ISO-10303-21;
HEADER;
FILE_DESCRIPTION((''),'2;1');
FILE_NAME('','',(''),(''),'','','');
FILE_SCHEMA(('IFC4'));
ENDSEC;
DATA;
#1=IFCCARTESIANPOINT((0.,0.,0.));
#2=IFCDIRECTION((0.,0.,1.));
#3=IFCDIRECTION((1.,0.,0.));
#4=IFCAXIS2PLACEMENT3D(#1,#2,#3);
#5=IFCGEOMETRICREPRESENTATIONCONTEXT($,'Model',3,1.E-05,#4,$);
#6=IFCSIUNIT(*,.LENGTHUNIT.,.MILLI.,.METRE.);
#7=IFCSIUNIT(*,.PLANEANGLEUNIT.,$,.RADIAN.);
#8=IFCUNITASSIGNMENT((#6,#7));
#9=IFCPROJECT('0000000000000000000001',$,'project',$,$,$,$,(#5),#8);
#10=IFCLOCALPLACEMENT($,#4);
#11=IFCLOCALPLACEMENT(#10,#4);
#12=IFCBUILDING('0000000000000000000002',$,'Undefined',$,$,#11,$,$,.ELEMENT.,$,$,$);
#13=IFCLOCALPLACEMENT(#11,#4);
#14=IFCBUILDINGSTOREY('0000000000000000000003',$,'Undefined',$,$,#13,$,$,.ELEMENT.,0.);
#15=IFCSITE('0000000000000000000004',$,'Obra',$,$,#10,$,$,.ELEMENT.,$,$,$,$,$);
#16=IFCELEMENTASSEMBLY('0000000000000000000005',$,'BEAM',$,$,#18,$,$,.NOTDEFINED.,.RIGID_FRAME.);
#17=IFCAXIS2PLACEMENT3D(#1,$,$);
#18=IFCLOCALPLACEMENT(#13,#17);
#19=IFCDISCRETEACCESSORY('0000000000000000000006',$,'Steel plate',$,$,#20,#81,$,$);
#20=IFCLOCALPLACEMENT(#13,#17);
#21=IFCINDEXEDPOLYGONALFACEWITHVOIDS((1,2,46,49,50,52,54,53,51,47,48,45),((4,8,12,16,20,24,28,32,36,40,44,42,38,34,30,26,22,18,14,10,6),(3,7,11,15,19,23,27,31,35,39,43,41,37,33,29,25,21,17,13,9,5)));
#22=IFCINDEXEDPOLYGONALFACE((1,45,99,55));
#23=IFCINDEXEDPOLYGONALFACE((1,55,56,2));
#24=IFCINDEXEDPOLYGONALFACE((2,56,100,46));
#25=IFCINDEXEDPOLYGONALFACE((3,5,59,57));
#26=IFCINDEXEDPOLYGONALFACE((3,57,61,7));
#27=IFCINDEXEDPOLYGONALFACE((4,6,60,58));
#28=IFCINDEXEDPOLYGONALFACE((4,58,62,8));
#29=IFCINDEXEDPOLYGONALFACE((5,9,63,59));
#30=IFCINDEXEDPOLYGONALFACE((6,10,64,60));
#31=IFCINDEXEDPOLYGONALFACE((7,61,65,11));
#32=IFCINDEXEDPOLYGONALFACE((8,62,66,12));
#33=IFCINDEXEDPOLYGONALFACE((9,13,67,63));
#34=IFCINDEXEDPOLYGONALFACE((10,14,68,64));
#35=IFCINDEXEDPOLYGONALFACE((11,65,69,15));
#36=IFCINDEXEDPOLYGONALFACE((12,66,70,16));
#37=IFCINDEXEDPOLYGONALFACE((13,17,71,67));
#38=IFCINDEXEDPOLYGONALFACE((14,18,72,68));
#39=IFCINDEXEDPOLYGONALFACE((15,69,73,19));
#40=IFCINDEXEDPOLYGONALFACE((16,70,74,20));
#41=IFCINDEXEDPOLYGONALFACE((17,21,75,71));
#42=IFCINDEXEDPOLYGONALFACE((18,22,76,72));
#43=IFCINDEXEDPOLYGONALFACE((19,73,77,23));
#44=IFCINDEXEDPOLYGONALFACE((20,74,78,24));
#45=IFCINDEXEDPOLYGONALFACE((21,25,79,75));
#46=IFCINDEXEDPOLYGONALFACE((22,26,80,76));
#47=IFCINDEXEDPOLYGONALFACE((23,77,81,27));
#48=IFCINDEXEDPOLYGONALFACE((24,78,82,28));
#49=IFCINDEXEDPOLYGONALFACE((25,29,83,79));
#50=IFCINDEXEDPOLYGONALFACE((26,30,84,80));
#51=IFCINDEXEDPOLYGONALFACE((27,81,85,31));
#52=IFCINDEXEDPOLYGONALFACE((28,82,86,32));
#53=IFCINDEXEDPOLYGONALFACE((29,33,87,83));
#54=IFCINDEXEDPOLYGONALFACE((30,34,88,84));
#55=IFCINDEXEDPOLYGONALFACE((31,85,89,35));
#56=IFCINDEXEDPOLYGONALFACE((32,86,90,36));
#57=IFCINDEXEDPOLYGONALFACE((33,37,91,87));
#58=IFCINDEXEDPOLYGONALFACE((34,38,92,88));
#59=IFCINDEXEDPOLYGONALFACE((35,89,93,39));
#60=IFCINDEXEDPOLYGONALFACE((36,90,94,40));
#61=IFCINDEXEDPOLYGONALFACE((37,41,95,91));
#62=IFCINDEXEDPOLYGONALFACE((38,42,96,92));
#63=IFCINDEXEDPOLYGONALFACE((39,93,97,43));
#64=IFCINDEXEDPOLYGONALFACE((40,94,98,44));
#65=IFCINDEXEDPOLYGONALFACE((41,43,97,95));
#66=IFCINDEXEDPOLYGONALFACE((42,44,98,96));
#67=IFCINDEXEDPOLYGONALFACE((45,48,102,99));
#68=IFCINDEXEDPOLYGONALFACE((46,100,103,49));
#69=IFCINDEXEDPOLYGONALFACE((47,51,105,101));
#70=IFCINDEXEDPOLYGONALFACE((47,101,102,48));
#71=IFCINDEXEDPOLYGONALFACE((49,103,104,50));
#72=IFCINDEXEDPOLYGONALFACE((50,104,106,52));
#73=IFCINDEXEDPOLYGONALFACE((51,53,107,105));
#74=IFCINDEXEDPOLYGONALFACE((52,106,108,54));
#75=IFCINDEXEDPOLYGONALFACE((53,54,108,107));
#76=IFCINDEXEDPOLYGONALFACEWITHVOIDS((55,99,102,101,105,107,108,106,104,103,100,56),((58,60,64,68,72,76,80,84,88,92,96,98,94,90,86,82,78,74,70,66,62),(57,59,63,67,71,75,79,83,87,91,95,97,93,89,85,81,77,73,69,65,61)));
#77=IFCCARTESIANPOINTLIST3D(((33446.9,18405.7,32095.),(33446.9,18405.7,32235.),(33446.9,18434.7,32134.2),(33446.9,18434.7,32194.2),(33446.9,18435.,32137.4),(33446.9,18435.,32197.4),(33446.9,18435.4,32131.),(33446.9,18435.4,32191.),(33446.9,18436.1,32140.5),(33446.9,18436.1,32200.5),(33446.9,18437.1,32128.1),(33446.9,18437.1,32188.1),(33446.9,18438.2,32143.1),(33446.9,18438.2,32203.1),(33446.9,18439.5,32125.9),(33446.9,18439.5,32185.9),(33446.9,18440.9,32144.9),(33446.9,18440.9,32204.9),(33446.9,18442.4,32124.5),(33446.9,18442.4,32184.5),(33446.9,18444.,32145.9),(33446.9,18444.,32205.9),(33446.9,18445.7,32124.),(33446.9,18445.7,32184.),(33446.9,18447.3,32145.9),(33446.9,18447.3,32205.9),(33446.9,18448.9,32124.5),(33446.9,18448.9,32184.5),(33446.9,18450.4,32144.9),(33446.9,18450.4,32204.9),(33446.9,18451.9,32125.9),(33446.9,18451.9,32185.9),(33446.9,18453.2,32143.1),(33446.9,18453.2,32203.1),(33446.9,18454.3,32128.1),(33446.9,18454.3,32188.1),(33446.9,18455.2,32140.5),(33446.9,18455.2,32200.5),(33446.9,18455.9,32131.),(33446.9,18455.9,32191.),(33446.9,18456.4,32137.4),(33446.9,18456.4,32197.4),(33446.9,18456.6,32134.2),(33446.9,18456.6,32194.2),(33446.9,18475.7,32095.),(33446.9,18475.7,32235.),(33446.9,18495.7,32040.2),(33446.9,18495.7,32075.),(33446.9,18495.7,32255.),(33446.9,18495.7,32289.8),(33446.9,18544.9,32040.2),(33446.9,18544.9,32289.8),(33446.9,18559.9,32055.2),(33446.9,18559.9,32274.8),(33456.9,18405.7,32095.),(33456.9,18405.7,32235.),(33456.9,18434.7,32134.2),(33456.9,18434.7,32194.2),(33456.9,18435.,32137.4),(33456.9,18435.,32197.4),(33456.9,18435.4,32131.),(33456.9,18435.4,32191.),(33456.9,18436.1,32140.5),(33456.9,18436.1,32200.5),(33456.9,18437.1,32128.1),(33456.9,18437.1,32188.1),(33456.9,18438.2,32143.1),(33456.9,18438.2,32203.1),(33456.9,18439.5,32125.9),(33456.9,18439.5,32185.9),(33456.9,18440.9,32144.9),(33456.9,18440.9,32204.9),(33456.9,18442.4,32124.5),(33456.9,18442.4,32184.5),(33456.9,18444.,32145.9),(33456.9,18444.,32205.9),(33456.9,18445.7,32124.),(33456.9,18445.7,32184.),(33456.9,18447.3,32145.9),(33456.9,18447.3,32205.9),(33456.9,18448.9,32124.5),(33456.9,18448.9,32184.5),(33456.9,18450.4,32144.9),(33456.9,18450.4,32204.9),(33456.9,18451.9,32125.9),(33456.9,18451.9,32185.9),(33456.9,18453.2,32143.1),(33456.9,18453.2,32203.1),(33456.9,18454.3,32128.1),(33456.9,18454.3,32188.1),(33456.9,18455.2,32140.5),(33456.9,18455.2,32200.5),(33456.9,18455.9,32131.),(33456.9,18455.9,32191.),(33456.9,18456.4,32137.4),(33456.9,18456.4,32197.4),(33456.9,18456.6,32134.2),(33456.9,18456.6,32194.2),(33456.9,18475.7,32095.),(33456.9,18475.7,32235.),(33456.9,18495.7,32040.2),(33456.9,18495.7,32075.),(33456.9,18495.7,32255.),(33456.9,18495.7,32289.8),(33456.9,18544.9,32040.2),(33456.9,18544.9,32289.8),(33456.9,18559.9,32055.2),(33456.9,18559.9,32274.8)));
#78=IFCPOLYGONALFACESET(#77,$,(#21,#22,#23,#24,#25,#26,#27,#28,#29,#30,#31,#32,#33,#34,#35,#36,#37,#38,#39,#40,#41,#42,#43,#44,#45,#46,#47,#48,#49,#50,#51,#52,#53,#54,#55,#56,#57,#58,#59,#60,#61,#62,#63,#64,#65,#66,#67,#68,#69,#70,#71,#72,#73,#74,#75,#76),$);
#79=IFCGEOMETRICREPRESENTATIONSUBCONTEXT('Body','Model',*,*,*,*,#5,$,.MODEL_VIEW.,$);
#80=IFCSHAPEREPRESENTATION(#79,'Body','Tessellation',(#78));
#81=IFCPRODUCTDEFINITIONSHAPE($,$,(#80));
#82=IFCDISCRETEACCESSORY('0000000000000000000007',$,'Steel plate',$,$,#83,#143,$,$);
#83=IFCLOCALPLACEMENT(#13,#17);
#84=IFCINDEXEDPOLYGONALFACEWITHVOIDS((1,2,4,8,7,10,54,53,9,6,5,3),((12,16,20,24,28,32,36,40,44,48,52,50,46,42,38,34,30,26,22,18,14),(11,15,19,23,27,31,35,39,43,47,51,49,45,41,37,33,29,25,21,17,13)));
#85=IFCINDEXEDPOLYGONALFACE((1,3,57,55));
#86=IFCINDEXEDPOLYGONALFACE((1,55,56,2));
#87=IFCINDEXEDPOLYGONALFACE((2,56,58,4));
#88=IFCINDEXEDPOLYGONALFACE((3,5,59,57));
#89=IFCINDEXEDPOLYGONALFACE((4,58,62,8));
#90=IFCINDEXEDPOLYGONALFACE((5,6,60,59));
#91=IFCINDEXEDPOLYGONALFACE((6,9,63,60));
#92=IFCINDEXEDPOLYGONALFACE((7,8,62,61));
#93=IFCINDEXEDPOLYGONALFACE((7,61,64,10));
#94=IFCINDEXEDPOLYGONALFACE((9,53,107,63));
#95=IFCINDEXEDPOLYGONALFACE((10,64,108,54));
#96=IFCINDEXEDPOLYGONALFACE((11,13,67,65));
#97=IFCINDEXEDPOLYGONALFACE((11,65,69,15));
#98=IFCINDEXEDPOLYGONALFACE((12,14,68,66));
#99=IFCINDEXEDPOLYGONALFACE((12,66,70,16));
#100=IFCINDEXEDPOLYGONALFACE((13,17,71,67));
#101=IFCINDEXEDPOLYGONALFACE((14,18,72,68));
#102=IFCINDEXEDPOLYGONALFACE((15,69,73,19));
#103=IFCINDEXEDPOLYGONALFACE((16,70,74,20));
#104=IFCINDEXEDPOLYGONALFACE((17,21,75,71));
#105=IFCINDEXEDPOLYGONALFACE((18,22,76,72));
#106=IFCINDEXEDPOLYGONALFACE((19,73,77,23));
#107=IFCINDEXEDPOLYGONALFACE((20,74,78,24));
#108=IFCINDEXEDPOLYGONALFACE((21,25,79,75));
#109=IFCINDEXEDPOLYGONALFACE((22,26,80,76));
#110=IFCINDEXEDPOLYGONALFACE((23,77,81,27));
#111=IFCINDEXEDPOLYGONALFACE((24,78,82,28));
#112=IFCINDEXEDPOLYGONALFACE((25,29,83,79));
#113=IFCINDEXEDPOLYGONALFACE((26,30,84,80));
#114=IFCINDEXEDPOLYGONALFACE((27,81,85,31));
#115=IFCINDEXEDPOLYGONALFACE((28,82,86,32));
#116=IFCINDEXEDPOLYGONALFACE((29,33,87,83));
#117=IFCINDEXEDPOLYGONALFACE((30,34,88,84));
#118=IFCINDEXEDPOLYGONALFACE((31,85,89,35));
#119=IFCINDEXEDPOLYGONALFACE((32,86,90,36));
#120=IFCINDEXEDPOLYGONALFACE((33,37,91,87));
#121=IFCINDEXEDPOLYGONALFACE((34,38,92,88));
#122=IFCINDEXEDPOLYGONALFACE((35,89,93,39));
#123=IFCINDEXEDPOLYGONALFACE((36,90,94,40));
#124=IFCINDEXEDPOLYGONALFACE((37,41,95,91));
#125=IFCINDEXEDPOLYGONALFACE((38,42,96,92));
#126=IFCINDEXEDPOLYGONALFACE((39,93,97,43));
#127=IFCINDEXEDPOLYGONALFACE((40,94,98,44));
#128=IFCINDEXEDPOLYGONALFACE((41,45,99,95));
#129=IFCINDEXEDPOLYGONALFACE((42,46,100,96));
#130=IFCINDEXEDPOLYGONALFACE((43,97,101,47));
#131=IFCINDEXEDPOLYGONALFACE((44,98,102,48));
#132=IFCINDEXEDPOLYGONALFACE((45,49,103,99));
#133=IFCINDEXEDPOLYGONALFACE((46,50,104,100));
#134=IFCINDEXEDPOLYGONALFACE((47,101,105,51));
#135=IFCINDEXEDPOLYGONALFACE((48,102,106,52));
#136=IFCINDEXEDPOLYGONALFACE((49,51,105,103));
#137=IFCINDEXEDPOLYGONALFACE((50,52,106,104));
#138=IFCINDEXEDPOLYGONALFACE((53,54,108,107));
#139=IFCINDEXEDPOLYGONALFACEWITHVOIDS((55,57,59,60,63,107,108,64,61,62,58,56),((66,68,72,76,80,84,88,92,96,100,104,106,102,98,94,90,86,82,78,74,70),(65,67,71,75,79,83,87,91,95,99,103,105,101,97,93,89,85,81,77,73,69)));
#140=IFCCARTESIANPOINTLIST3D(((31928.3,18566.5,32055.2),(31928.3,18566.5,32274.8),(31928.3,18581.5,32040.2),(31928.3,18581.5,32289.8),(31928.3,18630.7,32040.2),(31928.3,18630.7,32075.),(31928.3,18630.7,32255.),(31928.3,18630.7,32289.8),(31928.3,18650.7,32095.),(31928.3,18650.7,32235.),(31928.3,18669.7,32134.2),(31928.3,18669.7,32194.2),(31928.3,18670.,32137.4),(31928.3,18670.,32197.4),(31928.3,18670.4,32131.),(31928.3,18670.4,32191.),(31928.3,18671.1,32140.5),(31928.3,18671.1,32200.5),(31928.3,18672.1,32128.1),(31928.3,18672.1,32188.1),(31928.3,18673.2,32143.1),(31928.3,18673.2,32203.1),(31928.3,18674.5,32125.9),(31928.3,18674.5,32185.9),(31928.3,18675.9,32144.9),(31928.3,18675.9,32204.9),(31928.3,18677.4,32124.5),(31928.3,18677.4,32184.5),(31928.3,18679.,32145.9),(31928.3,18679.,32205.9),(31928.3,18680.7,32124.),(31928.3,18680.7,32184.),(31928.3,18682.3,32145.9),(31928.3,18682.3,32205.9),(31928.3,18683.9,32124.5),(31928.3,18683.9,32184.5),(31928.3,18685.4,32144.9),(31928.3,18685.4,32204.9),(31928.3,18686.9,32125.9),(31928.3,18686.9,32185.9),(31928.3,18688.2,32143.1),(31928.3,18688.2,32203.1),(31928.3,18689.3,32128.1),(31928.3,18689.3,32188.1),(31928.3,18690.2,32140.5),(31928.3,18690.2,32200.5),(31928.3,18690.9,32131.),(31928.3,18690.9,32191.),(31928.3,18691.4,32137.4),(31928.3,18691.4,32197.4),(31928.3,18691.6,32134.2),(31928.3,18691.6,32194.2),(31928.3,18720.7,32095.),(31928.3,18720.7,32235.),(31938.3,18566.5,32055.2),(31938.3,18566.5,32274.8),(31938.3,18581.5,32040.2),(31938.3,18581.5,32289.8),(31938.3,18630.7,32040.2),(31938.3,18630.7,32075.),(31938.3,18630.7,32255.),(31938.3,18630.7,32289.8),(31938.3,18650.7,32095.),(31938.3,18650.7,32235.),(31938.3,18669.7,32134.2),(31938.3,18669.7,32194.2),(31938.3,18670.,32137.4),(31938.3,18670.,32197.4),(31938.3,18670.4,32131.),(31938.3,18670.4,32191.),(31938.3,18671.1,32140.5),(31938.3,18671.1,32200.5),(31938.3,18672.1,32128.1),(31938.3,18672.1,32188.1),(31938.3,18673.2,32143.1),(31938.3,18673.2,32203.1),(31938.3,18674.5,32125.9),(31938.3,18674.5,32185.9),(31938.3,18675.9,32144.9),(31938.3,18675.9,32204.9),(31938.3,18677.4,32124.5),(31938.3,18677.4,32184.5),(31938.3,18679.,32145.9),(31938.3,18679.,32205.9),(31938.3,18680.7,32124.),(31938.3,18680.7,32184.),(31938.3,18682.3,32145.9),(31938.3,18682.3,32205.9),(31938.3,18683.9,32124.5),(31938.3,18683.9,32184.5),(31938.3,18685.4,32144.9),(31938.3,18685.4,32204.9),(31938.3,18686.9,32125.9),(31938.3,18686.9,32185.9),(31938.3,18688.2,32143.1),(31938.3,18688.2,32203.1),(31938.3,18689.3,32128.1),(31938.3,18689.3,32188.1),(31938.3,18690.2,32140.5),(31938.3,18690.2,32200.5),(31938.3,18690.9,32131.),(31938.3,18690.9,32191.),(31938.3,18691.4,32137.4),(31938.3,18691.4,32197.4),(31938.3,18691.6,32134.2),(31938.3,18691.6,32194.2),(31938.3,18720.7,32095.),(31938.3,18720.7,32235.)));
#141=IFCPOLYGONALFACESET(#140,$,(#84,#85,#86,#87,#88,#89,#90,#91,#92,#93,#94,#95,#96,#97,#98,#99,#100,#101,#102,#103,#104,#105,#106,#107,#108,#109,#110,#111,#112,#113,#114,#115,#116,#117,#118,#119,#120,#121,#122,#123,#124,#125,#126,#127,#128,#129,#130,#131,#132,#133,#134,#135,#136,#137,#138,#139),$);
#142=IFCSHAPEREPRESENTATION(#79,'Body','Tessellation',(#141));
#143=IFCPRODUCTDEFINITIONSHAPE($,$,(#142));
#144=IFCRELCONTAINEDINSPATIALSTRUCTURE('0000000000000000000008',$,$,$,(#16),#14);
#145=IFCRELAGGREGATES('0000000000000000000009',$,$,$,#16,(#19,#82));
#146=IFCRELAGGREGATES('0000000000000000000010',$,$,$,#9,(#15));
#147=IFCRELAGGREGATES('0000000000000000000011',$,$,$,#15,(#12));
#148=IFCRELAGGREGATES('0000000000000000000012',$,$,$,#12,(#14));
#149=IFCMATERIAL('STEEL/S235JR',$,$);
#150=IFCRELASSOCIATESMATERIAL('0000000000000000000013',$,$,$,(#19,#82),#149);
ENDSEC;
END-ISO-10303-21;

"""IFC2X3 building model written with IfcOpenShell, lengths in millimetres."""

from ifc_helpers import new_model, si_unit, frame, origin_with_axes, origin_2d_with_axis, place, context, subcontext, project, spatial, polyline, circle, outline, extrude, source, transform, mapped, material, element, aggregate, save


model = new_model("IFC2X3")

# Units and contexts
model_context = context("Model", 3, precision=1e-05, world=origin_with_axes())
body_context = subcontext(model_context, "Body", "Model", "MODEL_VIEW")
ifc_project = project(units=[si_unit("LENGTHUNIT", "METRE", prefix="MILLI"), si_unit("PLANEANGLEUNIT", "RADIAN")], contexts=[model_context])

# Site, building, storey
site_placement = place(None, origin_with_axes())
site = spatial("IfcSite", under=ifc_project, at=site_placement, Name="Obra", CompositionType="ELEMENT")
building_placement = place(site_placement, origin_with_axes())
building = spatial("IfcBuilding", under=site, at=building_placement, Name="Undefined", CompositionType="ELEMENT")
storey_placement = place(building_placement, origin_with_axes())
storey = spatial("IfcBuildingStorey", under=building, at=storey_placement, Name="Undefined", CompositionType="ELEMENT", Elevation=0.0)

# Shared definitions
ifc_material_1 = material(Name="STEEL/S235JR")

# Element assembly
assembly_1_placement = place(storey_placement, origin_with_axes())
assembly_1 = element("IfcElementAssembly", 1, at=assembly_1_placement, inside=storey, Name="BEAM", AssemblyPlace="NOTDEFINED", PredefinedType="RIGID_FRAME")

# Discrete accessories, openings
discrete_accessory_1_placement = place(assembly_1_placement, frame((33451.9, 18559.9, 32055.2), z_axis=(-1.0, 0.0, 0.0), x_axis=(0.0, -0.707107, -0.707107)))
discrete_accessory_1 = element("IfcDiscreteAccessory", 2, at=discrete_accessory_1_placement, material=ifc_material_1, Name="Steel plate", context=body_context, shape_type="SweptSolid", body=[
    extrude(outline(polyline([(0.0, 0.0), (21.2, 0.0), (56.0, 34.8), (31.4, 59.4), (31.4, 87.7), (80.9, 137.2), (-18.1, 236.2), (-67.6, 186.7), (-95.9, 186.7), (-120.5, 211.3), (-155.3, 176.5), (-155.3, 155.3), (0.0, 0.0)])), frame((0.0, 0.0, -5.0), z_axis=(0.0, 0.0, 1.0), x_axis=(1.0, 0.0, 0.0)), (0.0, 0.0, 1.0), 10.0),
])
shared_shape_1 = source(origin_with_axes(), body_context, "Body", "SweptSolid", [
    extrude(circle(Radius=11.0, at=origin_2d_with_axis()), frame((0.0, -13.4, 0.0), z_axis=(0.0, 1.0, 0.0), x_axis=(1.0, 0.0, 0.0)), (0.0, 0.0, 1.0), 10.2),
])
opening_1_placement = place(assembly_1_placement, frame((33460.2, 18485.7, 32235.0), z_axis=(0.0, -1.0, 0.0), x_axis=(0.0, 0.0, -1.0)))
element("IfcOpeningElement", 3, at=opening_1_placement, cuts=discrete_accessory_1, ObjectType="Opening", context=body_context, shape_type="MappedRepresentation", body=[
    mapped(shared_shape_1, transform((40.0, 0.0, 40.0))),
    mapped(shared_shape_1, transform((100.0, 0.0, 40.0))),
])
discrete_accessory_2_placement = place(assembly_1_placement, frame((31933.3, 18566.5, 32055.2), z_axis=(1.0, 0.0, 0.0), x_axis=(0.0, 0.707107, -0.707107)))
discrete_accessory_2 = element("IfcDiscreteAccessory", 4, at=discrete_accessory_2_placement, material=ifc_material_1, Name="Steel plate", context=body_context, shape_type="SweptSolid", body=[
    extrude(outline(polyline([(0.0, 0.0), (21.2, 0.0), (56.0, 34.8), (31.4, 59.4), (31.4, 87.7), (80.9, 137.2), (-18.1, 236.2), (-67.6, 186.7), (-95.9, 186.7), (-120.5, 211.3), (-155.3, 176.5), (-155.3, 155.3), (0.0, 0.0)])), frame((0.0, 0.0, -5.0), z_axis=(0.0, 0.0, 1.0), x_axis=(1.0, 0.0, 0.0)), (0.0, 0.0, 1.0), 10.0),
])
opening_2_placement = place(assembly_1_placement, frame((31925.0, 18640.7, 32235.0), z_axis=(0.0, 1.0, 0.0), x_axis=(0.0, 0.0, -1.0)))
element("IfcOpeningElement", 5, at=opening_2_placement, cuts=discrete_accessory_2, ObjectType="Opening", context=body_context, shape_type="MappedRepresentation", body=[
    mapped(shared_shape_1, transform((40.0, 0.0, 40.0))),
    mapped(shared_shape_1, transform((100.0, 0.0, 40.0))),
])
aggregate(assembly_1, [discrete_accessory_1, discrete_accessory_2])

save(model, "model.ifc")
